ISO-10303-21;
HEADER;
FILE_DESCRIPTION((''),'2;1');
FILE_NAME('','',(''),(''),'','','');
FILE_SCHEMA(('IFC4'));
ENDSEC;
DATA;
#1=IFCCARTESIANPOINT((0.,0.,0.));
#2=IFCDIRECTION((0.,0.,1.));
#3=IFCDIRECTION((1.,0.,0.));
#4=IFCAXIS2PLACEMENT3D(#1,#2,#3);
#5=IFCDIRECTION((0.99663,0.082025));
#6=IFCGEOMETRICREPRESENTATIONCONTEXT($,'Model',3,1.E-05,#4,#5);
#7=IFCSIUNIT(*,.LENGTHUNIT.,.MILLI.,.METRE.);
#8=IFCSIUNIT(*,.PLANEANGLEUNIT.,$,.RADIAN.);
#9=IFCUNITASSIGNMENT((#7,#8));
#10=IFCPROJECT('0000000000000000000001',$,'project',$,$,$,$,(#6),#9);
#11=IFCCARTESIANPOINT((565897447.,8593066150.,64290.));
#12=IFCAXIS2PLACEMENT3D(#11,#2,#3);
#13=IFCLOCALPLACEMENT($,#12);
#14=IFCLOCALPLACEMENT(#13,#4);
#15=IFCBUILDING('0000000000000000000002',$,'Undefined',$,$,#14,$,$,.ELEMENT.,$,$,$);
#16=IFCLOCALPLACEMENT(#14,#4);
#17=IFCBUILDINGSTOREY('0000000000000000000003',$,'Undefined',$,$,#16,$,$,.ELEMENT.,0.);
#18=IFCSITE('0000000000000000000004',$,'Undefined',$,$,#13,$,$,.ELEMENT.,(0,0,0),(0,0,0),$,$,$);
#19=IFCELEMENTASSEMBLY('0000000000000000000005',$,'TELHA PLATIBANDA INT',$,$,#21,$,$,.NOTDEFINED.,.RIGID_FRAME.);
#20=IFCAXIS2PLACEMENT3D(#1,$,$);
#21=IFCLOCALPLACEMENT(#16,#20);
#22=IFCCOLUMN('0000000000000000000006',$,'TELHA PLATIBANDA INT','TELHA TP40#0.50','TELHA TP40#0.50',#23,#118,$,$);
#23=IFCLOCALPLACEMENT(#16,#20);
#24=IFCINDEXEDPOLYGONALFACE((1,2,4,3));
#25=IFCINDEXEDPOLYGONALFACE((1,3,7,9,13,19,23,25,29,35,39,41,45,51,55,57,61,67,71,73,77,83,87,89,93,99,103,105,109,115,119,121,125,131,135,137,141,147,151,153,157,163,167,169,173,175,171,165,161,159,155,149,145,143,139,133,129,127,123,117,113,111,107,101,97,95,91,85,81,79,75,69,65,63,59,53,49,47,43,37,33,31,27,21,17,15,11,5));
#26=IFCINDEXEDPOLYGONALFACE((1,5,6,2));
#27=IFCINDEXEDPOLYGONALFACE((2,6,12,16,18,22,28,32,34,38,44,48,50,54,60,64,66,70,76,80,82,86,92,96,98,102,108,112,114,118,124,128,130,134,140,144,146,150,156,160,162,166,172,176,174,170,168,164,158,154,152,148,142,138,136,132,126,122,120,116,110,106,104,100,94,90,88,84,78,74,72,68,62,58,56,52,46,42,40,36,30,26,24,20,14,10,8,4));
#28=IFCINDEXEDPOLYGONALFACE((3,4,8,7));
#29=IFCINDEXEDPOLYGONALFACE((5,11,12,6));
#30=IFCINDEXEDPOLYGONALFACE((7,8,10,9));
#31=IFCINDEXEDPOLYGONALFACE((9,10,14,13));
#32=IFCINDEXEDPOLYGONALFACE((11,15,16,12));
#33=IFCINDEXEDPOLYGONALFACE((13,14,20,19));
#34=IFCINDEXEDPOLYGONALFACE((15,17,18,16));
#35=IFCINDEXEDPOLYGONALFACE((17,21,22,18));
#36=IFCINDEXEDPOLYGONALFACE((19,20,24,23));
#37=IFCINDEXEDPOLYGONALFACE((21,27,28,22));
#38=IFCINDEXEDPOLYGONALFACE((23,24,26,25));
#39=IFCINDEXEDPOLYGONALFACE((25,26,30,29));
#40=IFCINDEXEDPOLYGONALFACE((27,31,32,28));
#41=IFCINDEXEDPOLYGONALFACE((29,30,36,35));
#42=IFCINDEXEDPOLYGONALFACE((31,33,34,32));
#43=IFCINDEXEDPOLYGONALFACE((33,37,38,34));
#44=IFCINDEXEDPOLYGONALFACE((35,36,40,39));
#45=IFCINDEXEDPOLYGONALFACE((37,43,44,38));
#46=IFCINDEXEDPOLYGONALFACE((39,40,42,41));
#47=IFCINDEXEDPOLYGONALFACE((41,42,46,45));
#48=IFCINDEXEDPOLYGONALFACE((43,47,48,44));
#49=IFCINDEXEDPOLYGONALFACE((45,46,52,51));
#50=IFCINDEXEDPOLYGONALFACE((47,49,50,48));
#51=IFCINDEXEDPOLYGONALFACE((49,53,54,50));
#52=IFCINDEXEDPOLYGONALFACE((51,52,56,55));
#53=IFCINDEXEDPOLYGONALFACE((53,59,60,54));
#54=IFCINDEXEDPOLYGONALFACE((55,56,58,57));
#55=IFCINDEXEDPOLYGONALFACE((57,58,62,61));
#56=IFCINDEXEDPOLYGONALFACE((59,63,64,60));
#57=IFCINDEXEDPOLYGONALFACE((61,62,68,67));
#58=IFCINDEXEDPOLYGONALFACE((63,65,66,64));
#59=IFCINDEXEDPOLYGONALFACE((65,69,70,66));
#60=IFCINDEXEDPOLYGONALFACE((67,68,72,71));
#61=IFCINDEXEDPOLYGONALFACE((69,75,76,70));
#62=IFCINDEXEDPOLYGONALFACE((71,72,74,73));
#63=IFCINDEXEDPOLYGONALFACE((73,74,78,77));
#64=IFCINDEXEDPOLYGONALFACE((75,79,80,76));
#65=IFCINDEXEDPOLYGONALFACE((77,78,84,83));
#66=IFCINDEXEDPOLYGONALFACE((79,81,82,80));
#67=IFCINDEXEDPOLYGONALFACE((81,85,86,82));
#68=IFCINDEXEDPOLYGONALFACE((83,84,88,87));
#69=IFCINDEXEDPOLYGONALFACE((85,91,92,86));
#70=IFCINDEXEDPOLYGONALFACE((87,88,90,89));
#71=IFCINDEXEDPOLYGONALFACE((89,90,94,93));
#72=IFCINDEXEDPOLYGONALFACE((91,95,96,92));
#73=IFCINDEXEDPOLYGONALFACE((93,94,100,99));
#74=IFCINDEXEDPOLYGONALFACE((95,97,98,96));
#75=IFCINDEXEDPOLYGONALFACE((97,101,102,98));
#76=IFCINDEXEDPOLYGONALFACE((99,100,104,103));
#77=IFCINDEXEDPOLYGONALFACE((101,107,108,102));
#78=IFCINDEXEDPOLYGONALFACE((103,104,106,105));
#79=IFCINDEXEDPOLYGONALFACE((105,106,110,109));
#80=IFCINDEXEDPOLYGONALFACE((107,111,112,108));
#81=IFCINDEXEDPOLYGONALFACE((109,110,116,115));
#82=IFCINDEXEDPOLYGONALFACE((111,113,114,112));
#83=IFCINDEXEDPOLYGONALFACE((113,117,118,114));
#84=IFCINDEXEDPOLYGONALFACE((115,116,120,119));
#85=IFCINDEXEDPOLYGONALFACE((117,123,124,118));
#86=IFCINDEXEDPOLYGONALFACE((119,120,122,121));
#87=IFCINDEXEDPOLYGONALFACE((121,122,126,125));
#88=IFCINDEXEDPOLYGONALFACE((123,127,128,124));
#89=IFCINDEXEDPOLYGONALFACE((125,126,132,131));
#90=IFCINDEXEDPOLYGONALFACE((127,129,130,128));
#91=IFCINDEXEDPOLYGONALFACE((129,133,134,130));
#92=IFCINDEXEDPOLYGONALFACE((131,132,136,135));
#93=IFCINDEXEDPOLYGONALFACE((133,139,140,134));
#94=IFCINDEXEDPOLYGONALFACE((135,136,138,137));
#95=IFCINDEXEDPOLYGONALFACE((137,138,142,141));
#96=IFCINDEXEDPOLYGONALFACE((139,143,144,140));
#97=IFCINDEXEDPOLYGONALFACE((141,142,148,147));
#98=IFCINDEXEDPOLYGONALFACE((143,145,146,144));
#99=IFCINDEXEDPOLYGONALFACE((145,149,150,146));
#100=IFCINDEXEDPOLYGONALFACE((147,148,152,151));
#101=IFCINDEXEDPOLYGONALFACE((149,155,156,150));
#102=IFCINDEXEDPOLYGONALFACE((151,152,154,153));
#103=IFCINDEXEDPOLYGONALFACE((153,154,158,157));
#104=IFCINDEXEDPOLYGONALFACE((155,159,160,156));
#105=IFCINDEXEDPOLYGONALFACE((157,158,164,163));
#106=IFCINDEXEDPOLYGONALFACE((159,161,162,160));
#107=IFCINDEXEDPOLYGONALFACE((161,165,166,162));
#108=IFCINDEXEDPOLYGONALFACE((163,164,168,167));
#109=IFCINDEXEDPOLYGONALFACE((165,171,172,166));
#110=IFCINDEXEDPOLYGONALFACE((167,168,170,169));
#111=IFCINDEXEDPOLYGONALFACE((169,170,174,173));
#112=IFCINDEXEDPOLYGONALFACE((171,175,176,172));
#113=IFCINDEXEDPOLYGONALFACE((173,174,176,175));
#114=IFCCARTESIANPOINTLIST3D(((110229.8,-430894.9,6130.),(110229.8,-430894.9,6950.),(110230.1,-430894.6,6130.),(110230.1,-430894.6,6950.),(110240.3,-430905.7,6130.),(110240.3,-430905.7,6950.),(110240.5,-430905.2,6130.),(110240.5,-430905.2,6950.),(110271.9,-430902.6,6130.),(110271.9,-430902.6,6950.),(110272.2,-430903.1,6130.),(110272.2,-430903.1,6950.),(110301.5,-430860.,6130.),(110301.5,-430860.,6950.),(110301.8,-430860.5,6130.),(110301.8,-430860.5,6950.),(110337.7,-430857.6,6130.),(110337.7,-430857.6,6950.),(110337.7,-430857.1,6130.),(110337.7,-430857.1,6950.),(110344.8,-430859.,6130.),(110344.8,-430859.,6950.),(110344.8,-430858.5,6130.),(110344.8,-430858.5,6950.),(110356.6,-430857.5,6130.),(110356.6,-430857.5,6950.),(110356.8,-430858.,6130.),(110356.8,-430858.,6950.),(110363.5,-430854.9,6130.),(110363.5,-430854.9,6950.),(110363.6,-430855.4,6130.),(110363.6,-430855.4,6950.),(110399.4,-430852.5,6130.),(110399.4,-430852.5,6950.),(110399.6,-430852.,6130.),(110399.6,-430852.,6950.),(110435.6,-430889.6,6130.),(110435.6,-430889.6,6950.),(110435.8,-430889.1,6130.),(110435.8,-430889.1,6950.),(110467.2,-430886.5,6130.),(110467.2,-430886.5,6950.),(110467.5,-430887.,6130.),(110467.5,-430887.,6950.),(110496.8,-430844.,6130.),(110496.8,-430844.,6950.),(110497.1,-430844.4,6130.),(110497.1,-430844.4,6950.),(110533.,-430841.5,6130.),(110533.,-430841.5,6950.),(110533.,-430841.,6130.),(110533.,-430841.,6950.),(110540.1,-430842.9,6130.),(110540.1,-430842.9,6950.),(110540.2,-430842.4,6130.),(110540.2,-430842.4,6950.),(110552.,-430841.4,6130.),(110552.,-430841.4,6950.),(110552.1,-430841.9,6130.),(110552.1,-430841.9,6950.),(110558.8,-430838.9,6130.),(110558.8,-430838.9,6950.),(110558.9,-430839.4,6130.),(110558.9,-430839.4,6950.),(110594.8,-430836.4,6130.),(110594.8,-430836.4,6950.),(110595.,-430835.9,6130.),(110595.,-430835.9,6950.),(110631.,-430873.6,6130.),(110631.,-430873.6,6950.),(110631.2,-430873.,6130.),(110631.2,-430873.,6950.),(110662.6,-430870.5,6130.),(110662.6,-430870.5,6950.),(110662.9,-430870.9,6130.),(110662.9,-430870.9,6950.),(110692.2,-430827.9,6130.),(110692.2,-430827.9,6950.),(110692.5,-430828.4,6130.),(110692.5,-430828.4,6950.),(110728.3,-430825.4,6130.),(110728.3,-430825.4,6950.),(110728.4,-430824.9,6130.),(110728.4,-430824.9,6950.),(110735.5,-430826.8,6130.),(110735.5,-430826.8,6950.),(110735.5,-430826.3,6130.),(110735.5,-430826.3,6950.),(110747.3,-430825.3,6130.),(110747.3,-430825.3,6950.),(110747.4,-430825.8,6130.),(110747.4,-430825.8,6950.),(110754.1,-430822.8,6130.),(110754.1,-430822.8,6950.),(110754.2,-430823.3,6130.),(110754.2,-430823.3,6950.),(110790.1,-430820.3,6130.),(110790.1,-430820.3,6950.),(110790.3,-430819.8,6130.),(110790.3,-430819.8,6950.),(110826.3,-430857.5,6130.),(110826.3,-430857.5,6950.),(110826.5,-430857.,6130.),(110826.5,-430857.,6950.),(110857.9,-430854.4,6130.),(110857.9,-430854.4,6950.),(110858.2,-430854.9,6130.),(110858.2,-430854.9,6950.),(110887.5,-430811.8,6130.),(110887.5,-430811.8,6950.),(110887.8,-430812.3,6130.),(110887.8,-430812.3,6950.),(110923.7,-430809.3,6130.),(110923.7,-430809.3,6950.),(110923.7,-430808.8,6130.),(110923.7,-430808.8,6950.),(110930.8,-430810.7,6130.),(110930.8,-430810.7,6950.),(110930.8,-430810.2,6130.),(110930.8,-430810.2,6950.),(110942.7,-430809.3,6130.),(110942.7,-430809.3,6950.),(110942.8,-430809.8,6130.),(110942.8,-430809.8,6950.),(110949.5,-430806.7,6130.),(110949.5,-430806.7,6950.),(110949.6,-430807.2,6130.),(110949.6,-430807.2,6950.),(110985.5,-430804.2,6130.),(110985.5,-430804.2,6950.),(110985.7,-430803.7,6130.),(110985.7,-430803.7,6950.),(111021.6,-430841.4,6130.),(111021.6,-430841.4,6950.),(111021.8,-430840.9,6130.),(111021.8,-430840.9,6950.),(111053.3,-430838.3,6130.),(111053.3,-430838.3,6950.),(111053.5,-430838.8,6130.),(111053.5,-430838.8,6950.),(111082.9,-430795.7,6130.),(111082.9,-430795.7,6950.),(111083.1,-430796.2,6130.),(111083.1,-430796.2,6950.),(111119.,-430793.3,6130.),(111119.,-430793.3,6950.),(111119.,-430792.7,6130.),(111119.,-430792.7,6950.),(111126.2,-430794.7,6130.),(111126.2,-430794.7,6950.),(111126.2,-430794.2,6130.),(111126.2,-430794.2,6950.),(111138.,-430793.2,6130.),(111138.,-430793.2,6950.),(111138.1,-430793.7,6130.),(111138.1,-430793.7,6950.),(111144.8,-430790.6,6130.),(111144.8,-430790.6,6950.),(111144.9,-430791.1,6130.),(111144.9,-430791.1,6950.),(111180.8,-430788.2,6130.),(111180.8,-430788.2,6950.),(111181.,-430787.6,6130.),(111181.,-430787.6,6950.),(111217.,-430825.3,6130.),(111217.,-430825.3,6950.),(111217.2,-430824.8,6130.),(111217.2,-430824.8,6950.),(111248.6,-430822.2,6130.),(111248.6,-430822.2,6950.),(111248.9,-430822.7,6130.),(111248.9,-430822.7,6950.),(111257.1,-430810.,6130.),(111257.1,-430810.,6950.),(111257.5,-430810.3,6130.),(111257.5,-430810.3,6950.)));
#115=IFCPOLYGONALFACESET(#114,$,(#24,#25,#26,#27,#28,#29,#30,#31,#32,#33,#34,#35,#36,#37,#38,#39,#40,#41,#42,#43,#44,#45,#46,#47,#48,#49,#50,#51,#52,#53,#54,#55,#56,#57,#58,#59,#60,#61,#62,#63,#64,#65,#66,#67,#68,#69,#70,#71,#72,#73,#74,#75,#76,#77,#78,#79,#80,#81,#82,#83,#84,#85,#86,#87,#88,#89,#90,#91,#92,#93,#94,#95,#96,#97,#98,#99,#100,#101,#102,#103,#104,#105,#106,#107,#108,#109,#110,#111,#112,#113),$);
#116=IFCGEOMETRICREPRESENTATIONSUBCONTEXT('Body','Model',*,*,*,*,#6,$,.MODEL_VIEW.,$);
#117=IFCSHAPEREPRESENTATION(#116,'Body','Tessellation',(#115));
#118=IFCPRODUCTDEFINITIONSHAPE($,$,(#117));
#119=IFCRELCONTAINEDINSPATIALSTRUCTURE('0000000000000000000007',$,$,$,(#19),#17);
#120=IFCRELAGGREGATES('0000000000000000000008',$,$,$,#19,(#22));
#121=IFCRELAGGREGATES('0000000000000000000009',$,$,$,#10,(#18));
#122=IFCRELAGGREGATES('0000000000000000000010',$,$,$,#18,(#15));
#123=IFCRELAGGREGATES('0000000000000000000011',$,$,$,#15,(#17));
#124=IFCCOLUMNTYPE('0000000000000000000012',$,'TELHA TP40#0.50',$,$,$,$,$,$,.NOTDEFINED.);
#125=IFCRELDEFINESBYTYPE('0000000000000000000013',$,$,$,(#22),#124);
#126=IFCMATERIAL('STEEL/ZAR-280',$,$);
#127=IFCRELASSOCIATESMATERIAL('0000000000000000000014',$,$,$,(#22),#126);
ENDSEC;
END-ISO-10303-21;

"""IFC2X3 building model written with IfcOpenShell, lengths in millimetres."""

from ifc_helpers import new_model, si_unit, direction, frame, origin_with_axes, place, context, subcontext, project, spatial, polyline, outline, extrude, material, type_object, element, aggregate, save


model = new_model("IFC2X3")

# Units and contexts
model_context = context("Model", 3, precision=1e-05, world=origin_with_axes(), true_north=direction((0.99663, 0.082025)))
body_context = subcontext(model_context, "Body", "Model", "MODEL_VIEW")
ifc_project = project(units=[si_unit("LENGTHUNIT", "METRE", prefix="MILLI"), si_unit("PLANEANGLEUNIT", "RADIAN")], contexts=[model_context])

# Site, building, storey
site_placement = place(None, frame((565897447.0, 8593066150.0, 64290.0), z_axis=(0.0, 0.0, 1.0), x_axis=(1.0, 0.0, 0.0)))
site = spatial("IfcSite", under=ifc_project, at=site_placement, Name="Undefined", CompositionType="ELEMENT", RefLatitude=(0, 0, 0), RefLongitude=(0, 0, 0))
building_placement = place(site_placement, origin_with_axes())
building = spatial("IfcBuilding", under=site, at=building_placement, Name="Undefined", CompositionType="ELEMENT")
storey_placement = place(building_placement, origin_with_axes())
storey = spatial("IfcBuildingStorey", under=building, at=storey_placement, Name="Undefined", CompositionType="ELEMENT", Elevation=0.0)

# Element assembly, column
ifc_material_1 = material(Name="STEEL/ZAR-280")
column_type = type_object("IfcColumnType", Name="TELHA TP40#0.50", PredefinedType="NOTDEFINED")
assembly_1_placement = place(storey_placement, origin_with_axes())
assembly_1 = element("IfcElementAssembly", 1, at=assembly_1_placement, inside=storey, Name="TELHA PLATIBANDA INT", AssemblyPlace="NOTDEFINED", PredefinedType="RIGID_FRAME")
column_1_placement = place(assembly_1_placement, frame((110743.1, -430844.0, 6130.0), z_axis=(0.0, 0.0, 1.0), x_axis=(0.082025, -0.99663, 0.0)))
column_1 = element("IfcColumn", 2, at=column_1_placement, type_object=column_type, material=ifc_material_1, Name="TELHA PLATIBANDA INT", Description="TELHA TP40#0.50", ObjectType="TELHA TP40#0.50", context=body_context, shape_type="SweptSolid", body=[
    extrude(outline(polyline([(440.8, -19.8), (473.8, 20.2), (505.8, 20.2), (515.4, 8.6), (515.0, 8.3), (505.6, 19.8), (474.0, 19.8), (441.0, -20.2), (404.7, -20.2), (397.7, -18.2), (385.9, -18.2), (378.9, -20.2), (342.6, -20.2), (309.6, 19.8), (278.0, 19.8), (245.0, -20.2), (208.7, -20.2), (201.7, -18.2), (189.9, -18.2), (182.9, -20.2), (146.6, -20.2), (113.6, 19.8), (82.0, 19.8), (49.0, -20.2), (12.7, -20.2), (5.7, -18.2), (-6.1, -18.2), (-13.1, -20.2), (-49.4, -20.2), (-82.4, 19.8), (-114.0, 19.8), (-147.0, -20.2), (-183.3, -20.2), (-190.3, -18.2), (-202.1, -18.2), (-209.1, -20.2), (-245.4, -20.2), (-278.4, 19.8), (-310.0, 19.8), (-343.0, -20.2), (-379.3, -20.2), (-386.3, -18.2), (-398.1, -18.2), (-405.1, -20.2), (-441.4, -20.2), (-474.4, 19.8), (-506.0, 19.8), (-515.4, 8.3), (-515.8, 8.6), (-506.2, 20.2), (-474.2, 20.2), (-441.2, -19.8), (-405.2, -19.8), (-398.2, -17.8), (-386.2, -17.8), (-379.2, -19.8), (-343.2, -19.8), (-310.2, 20.2), (-278.2, 20.2), (-245.2, -19.8), (-209.2, -19.8), (-202.2, -17.8), (-190.2, -17.8), (-183.2, -19.8), (-147.2, -19.8), (-114.2, 20.2), (-82.2, 20.2), (-49.2, -19.8), (-13.2, -19.8), (-6.2, -17.8), (5.8, -17.8), (12.8, -19.8), (48.8, -19.8), (81.8, 20.2), (113.8, 20.2), (146.8, -19.8), (182.8, -19.8), (189.8, -17.8), (201.8, -17.8), (208.8, -19.8), (244.8, -19.8), (277.8, 20.2), (309.8, 20.2), (342.8, -19.8), (378.8, -19.8), (385.8, -17.8), (397.8, -17.8), (404.8, -19.8), (440.8, -19.8)])), frame((0.0, 0.0, 820.0), z_axis=(0.0, 0.0, -1.0), x_axis=(0.0, 1.0, 0.0)), (0.0, 0.0, 1.0), 820.0),
])
aggregate(assembly_1, [column_1])

save(model, "model.ifc")
